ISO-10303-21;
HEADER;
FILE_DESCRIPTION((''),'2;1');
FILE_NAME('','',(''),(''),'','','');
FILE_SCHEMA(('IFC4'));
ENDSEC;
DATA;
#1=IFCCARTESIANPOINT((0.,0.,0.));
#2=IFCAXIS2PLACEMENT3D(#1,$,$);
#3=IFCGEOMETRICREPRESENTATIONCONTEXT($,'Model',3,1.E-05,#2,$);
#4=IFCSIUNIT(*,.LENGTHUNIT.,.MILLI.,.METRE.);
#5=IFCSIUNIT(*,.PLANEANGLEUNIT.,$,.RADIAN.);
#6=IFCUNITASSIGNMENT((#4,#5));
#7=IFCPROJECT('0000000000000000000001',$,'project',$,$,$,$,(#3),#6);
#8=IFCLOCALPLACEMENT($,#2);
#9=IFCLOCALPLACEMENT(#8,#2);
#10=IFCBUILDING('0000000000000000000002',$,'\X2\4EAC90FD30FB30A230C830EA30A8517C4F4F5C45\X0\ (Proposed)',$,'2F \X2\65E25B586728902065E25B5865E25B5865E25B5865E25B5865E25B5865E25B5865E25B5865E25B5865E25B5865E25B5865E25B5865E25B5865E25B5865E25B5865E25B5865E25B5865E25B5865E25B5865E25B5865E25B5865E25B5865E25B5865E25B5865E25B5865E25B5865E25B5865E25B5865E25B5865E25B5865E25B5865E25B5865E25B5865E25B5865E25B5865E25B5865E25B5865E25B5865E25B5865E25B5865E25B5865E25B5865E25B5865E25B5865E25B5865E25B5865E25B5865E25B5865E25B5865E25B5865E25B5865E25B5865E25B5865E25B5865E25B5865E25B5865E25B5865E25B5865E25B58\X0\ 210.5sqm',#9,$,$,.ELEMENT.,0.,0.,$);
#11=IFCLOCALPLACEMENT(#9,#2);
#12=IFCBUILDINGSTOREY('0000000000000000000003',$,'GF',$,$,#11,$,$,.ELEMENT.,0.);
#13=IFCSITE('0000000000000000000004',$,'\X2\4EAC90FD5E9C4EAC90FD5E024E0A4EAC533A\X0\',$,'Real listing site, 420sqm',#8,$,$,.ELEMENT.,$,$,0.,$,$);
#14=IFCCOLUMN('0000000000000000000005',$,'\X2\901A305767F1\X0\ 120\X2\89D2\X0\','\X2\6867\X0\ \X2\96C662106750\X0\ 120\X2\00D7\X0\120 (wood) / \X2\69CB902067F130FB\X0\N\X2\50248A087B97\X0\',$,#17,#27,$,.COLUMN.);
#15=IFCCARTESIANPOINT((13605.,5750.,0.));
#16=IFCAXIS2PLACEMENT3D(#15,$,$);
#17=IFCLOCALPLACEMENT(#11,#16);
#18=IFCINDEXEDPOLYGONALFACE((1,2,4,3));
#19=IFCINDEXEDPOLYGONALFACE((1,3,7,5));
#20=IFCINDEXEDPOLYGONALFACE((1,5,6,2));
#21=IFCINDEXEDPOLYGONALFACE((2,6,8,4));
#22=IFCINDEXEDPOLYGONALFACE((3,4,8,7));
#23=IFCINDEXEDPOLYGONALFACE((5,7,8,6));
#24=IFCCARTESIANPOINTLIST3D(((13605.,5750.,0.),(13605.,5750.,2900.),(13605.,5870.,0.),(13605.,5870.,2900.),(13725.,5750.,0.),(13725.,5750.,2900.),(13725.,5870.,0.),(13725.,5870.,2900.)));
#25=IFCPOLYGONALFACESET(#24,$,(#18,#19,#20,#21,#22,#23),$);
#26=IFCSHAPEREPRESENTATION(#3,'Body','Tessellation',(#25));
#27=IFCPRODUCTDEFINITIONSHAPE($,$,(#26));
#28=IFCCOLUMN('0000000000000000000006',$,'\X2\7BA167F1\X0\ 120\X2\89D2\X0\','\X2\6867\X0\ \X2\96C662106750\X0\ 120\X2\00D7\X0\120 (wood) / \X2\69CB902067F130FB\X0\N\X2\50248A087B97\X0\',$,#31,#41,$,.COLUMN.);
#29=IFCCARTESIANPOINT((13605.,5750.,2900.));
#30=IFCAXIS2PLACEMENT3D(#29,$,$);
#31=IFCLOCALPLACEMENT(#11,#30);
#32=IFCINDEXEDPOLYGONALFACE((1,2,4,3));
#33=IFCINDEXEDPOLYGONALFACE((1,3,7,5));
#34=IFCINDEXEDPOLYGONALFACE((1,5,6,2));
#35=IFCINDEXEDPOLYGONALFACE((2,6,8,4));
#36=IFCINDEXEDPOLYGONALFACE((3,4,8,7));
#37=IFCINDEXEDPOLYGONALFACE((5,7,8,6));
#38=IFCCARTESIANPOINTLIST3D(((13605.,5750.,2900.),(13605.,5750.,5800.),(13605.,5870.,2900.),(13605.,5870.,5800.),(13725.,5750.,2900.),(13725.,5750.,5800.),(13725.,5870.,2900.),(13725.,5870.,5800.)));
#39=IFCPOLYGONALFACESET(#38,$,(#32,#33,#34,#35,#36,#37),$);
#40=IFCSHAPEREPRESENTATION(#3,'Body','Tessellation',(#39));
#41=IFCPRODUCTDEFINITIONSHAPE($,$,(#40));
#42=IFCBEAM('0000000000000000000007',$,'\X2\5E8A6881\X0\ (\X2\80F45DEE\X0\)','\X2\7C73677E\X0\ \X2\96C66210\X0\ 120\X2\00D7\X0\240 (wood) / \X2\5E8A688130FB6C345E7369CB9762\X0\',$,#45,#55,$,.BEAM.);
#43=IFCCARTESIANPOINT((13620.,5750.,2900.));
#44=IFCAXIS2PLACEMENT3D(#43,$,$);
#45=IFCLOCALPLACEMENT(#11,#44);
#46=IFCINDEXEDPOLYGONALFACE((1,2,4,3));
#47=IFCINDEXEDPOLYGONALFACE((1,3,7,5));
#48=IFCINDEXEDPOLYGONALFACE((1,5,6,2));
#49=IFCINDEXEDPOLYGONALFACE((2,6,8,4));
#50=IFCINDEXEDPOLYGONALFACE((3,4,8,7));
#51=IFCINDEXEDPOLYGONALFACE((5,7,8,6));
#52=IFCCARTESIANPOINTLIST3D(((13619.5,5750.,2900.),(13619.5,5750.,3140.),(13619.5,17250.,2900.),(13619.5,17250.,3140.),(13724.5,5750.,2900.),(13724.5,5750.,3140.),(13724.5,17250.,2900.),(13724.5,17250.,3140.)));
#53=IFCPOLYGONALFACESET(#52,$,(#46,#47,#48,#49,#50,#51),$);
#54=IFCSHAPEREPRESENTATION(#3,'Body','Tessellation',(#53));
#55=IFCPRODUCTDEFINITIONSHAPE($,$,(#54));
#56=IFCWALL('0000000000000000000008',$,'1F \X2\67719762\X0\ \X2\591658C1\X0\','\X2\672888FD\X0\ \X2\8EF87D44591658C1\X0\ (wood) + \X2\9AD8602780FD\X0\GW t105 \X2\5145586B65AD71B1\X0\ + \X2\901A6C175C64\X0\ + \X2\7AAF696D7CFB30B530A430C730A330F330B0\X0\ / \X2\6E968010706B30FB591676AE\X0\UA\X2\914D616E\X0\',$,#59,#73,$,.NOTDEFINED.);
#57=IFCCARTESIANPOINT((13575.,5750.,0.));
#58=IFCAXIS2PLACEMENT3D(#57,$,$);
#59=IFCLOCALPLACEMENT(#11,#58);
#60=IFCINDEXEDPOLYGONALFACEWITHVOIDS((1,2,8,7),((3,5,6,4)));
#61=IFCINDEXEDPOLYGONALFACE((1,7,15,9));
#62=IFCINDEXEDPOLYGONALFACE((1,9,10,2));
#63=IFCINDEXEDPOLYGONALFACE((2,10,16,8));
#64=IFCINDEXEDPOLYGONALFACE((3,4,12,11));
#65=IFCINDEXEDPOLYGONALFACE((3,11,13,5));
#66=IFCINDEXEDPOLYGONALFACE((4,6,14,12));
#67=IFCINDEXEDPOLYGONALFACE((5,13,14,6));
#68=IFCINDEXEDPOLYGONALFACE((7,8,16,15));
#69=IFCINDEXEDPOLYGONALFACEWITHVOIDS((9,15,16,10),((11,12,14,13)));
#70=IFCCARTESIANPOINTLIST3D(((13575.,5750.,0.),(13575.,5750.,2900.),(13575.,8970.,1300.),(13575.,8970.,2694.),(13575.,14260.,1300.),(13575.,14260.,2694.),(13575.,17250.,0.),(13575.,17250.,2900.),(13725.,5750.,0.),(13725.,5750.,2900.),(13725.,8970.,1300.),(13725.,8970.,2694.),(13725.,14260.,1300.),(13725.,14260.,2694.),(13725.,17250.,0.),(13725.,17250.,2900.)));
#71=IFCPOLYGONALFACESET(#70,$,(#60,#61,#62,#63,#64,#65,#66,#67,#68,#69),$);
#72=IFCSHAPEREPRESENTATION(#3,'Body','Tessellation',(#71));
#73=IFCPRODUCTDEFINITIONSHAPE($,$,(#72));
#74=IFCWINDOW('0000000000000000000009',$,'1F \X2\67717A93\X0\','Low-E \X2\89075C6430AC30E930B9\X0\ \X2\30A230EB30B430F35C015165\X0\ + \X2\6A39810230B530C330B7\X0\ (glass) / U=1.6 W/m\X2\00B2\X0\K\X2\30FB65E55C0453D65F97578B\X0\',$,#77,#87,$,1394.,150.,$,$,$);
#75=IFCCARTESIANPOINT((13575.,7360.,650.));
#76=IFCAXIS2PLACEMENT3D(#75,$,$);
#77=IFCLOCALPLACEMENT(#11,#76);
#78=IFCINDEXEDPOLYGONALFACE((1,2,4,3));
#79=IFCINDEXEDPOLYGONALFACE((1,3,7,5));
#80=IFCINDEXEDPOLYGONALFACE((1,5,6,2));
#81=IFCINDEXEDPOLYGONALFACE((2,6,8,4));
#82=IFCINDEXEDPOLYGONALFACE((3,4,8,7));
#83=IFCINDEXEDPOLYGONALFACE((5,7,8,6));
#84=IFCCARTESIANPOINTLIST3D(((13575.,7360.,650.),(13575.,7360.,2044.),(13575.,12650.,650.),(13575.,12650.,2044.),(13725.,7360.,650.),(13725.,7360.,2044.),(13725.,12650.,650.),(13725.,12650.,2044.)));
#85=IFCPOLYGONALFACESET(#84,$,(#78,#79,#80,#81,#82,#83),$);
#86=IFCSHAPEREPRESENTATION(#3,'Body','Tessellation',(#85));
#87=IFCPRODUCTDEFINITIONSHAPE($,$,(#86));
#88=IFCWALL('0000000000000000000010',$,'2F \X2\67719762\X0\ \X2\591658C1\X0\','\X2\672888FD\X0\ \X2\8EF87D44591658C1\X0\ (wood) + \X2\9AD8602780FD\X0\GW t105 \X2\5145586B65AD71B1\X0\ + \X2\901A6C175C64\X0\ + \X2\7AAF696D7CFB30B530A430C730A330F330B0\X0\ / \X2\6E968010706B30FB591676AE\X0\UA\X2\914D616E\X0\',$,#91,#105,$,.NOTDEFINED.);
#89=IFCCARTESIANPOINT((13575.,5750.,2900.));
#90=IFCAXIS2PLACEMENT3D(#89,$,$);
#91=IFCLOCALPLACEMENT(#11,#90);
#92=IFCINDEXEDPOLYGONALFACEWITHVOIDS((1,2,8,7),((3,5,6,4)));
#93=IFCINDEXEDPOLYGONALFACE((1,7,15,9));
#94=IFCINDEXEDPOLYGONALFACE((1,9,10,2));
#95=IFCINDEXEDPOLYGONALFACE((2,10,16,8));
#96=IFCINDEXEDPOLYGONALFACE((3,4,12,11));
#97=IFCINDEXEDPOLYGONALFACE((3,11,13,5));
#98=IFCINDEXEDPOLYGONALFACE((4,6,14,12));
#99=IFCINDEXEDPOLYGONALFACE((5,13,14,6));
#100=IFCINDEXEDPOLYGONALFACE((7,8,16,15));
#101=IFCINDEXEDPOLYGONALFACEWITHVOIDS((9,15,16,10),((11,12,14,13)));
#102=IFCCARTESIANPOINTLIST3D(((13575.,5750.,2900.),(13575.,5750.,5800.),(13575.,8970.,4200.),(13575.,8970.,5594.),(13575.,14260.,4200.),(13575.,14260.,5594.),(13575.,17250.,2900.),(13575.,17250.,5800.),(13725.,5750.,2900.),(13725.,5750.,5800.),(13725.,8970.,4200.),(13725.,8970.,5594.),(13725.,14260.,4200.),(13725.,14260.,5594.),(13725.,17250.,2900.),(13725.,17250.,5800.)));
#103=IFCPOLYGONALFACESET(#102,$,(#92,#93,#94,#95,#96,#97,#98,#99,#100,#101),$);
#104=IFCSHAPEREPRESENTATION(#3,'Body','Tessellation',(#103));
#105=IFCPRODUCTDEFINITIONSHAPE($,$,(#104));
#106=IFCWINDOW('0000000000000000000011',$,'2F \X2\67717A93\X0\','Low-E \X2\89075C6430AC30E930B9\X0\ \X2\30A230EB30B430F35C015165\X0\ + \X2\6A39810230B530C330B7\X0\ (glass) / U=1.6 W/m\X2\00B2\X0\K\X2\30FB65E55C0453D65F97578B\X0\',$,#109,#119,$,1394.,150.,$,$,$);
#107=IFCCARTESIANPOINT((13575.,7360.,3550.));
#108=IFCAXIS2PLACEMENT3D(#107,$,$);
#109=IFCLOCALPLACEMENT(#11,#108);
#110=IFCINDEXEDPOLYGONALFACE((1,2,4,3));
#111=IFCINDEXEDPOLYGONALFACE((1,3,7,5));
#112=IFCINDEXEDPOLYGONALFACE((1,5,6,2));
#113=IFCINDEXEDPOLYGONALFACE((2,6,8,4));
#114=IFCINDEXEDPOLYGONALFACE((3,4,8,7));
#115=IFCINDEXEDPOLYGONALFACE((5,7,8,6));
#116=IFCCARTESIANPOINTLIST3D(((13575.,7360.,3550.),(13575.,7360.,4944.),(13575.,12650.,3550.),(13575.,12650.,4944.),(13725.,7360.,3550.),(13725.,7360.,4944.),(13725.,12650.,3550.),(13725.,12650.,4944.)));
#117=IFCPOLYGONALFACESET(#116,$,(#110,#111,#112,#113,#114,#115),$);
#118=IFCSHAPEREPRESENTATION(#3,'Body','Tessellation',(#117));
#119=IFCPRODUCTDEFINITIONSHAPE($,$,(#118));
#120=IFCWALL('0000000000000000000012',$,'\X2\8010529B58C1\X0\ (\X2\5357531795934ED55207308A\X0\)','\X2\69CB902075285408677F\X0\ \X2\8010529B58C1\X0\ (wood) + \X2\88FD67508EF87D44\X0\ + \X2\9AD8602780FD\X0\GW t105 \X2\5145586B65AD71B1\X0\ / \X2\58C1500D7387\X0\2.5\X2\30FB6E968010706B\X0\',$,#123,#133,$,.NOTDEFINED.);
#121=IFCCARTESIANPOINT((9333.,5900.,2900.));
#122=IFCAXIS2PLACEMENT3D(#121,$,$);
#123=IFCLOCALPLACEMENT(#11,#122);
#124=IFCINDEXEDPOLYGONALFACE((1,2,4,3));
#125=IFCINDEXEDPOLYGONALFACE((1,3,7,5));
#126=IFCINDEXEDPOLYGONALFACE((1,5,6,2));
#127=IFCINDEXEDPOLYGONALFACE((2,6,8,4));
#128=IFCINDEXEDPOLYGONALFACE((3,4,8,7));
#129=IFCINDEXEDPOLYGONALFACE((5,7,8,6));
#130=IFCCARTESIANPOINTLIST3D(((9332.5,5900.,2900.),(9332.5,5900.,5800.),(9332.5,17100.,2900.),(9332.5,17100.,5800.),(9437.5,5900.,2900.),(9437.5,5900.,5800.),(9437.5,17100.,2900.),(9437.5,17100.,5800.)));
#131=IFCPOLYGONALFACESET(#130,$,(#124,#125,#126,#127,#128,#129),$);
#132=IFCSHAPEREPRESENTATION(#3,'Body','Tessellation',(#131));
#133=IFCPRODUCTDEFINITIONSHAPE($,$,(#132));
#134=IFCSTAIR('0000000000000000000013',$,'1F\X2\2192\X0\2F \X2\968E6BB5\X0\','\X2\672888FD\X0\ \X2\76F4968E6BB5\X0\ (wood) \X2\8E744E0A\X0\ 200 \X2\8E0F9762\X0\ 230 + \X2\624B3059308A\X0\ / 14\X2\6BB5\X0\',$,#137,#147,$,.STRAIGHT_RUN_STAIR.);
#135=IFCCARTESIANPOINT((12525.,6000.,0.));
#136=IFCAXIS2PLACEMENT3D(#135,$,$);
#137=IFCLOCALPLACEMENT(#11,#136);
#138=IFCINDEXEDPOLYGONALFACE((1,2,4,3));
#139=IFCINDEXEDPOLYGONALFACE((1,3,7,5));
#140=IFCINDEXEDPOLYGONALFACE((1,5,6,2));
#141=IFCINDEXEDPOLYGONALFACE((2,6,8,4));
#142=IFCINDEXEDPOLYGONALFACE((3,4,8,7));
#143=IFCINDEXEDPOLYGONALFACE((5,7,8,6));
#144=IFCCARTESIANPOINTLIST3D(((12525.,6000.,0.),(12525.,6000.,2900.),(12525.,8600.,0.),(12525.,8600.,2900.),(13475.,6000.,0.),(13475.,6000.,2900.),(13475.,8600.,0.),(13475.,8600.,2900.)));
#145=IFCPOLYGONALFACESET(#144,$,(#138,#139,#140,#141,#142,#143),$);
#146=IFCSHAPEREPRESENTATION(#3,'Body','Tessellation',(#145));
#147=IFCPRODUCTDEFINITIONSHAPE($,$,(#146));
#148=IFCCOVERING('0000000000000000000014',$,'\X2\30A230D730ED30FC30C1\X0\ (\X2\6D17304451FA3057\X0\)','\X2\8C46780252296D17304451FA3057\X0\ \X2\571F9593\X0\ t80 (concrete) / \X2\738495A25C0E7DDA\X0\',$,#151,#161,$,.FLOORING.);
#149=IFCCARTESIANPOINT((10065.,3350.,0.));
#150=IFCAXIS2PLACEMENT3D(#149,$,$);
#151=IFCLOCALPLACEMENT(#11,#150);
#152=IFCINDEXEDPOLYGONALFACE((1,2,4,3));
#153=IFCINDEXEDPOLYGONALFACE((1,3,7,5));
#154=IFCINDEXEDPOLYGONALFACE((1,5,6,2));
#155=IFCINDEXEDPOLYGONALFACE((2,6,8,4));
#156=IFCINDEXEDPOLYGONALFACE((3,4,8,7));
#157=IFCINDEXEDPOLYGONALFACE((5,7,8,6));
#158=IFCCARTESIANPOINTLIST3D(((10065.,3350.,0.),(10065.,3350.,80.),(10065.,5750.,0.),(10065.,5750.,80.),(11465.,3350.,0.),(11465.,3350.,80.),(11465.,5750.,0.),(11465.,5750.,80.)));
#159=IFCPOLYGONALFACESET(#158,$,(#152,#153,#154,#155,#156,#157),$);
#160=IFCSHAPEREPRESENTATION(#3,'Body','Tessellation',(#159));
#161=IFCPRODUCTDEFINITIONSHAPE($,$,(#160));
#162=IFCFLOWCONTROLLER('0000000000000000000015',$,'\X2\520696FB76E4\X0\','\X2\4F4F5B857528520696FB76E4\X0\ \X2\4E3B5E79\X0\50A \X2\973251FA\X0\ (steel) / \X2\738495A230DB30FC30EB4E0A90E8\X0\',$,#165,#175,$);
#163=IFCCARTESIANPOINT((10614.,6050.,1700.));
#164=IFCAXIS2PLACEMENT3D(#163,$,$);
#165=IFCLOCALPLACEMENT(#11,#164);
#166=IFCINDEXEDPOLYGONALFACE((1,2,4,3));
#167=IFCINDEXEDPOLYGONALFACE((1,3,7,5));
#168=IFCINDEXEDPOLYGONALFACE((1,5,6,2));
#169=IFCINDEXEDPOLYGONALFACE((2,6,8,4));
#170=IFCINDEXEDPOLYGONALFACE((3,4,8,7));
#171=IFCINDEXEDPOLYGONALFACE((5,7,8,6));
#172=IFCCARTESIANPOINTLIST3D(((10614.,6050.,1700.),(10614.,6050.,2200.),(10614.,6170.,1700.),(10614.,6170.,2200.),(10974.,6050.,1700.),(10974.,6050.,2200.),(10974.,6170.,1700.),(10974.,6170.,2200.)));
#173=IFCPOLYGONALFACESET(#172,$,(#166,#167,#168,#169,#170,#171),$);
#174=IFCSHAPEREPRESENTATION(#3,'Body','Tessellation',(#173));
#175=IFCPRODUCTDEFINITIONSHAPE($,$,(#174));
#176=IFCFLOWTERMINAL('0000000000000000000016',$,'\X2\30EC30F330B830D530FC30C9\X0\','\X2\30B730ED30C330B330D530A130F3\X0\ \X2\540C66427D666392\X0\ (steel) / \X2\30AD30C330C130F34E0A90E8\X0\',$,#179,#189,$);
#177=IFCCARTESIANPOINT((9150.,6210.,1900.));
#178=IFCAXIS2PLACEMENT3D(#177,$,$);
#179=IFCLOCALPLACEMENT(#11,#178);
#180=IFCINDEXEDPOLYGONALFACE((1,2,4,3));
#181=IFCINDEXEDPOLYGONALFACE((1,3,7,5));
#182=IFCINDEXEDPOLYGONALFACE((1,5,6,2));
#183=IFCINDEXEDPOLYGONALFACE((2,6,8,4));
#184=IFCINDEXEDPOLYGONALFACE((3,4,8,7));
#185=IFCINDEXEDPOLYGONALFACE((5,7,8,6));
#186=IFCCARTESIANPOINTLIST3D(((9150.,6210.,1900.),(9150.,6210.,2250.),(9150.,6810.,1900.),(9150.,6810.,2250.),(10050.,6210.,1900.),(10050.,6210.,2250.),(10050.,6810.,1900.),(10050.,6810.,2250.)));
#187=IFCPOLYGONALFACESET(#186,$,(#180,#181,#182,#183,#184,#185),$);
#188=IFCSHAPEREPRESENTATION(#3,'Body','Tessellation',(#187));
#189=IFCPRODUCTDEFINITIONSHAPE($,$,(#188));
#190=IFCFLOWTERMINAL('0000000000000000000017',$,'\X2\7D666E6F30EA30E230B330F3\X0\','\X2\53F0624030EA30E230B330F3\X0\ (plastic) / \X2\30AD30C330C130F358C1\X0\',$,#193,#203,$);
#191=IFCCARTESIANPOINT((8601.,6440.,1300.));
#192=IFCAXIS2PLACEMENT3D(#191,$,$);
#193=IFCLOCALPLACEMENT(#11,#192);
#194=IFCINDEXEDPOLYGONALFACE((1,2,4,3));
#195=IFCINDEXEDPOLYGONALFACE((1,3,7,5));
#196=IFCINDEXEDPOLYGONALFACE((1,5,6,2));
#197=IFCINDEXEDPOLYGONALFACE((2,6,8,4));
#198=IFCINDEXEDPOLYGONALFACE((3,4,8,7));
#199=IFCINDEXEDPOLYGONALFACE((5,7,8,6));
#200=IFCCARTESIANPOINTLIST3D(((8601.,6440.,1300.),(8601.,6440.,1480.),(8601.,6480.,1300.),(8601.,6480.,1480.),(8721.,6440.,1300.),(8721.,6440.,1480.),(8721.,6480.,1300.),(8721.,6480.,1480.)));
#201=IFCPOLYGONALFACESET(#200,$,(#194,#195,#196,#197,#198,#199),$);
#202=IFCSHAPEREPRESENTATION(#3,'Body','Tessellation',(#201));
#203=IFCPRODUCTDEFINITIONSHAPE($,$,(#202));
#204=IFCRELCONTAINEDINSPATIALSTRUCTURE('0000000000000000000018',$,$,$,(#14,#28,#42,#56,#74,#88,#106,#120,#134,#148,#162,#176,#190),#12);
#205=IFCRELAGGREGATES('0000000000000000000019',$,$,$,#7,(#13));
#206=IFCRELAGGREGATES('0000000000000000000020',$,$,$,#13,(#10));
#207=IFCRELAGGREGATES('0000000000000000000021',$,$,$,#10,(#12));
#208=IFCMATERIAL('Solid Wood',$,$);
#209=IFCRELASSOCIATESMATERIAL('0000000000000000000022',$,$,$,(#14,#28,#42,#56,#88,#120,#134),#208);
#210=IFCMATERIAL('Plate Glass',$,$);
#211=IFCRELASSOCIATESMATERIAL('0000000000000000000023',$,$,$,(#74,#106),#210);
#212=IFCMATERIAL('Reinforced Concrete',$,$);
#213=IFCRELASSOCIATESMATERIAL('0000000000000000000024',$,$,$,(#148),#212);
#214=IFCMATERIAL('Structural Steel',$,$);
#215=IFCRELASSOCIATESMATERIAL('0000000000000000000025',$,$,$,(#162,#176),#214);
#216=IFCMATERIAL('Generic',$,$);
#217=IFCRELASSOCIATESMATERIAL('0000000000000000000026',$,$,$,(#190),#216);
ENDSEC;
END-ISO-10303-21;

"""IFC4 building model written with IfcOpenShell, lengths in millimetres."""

from ifc_helpers import new_model, si_unit, frame, frame_2d, origin, place, context, project, spatial, rectangle, extrude, material, element, fill, save


model = new_model("IFC4")

# Units and contexts
model_context = context("Model", 3, precision=1e-05, world=origin())
ifc_project = project(units=[si_unit("LENGTHUNIT", "METRE", prefix="MILLI"), si_unit("PLANEANGLEUNIT", "RADIAN")], contexts=[model_context])

# Site, building, storey
site_placement = place(None, origin())
site = spatial("IfcSite", under=ifc_project, at=site_placement, Name="京都府京都市上京区", ObjectType="Real listing site, 420sqm", CompositionType="ELEMENT", RefElevation=0.0)
building_placement = place(site_placement, origin())
building = spatial("IfcBuilding", under=site, at=building_placement, Name="京都・アトリエ兼住居 (Proposed)", ObjectType="2F 既存木造既存既存既存既存既存既存既存既存既存既存既存既存既存既存既存既存既存既存既存既存既存既存既存既存既存既存既存既存既存既存既存既存既存既存既存既存既存既存既存既存既存既存既存既存既存既存既存既存既存既存既存既存既存既存既存既存既存既存 210.5sqm", CompositionType="ELEMENT", ElevationOfRefHeight=0.0, ElevationOfTerrain=0.0)
storey_placement = place(building_placement, origin())
storey = spatial("IfcBuildingStorey", under=building, at=storey_placement, Name="GF", CompositionType="ELEMENT", Elevation=0.0)

# Columns
ifc_material_1 = material(Name="Solid Wood")
column_1_placement = place(storey_placement, frame((13605.0, 5750.0, 0.0)))
element("IfcColumn", 1, at=column_1_placement, inside=storey, material=ifc_material_1, Name="通し柱 120角", Description="桧 集成材 120×120 (wood) / 構造柱・N値計算", PredefinedType="COLUMN", context=model_context, shape_type="SweptSolid", body=[
    extrude(rectangle(XDim=120.0, YDim=120.0, at=frame_2d((60.0, 60.0))), frame((13605.0, 5750.0, 0.0)), (0.0, 0.0, 1.0), 2900.0),
])
column_2_placement = place(storey_placement, frame((13605.0, 5750.0, 2900.0)))
element("IfcColumn", 2, at=column_2_placement, inside=storey, material=ifc_material_1, Name="管柱 120角", Description="桧 集成材 120×120 (wood) / 構造柱・N値計算", PredefinedType="COLUMN", context=model_context, shape_type="SweptSolid", body=[
    extrude(rectangle(XDim=120.0, YDim=120.0, at=frame_2d((60.0, 60.0))), frame((13605.0, 5750.0, 2900.0)), (0.0, 0.0, 1.0), 2900.0),
])

# Beam
beam_1_placement = place(storey_placement, frame((13620.0, 5750.0, 2900.0)))
element("IfcBeam", 3, at=beam_1_placement, inside=storey, material=ifc_material_1, Name="床梁 (胴差)", Description="米松 集成 120×240 (wood) / 床梁・水平構面", PredefinedType="BEAM", context=model_context, shape_type="SweptSolid", body=[
    extrude(rectangle(XDim=105.0, YDim=11500.0, at=frame_2d((52.0, 5750.0))), frame((13620.0, 5750.0, 2900.0)), (0.0, 0.0, 1.0), 240.0),
])

# Wall, opening, window
wall_1_placement = place(storey_placement, frame((13575.0, 5750.0, 0.0)))
wall_1 = element("IfcWall", 4, at=wall_1_placement, inside=storey, material=ifc_material_1, Name="1F 東面 外壁", Description="木製 軸組外壁 (wood) + 高性能GW t105 充填断熱 + 通気層 + 窯業系サイディング / 準耐火・外皮UA配慮", PredefinedType="NOTDEFINED", context=model_context, shape_type="SweptSolid", body=[
    extrude(rectangle(XDim=150.0, YDim=11500.0, at=frame_2d((75.0, 5750.0))), frame((13575.0, 5750.0, 0.0)), (0.0, 0.0, 1.0), 2900.0),
])
opening_1_placement = place(storey_placement, frame((13575.0, 7360.0, 650.0)))
opening_1 = element("IfcOpeningElement", 5, at=opening_1_placement, cuts=wall_1, PredefinedType="NOTDEFINED", context=model_context, shape_type="SweptSolid", body=[
    extrude(rectangle(XDim=150.0, YDim=5290.0, at=frame_2d((75.0, 2645.0))), frame((13575.0, 7360.0, 650.0)), (0.0, 0.0, 1.0), 1394.0),
])
ifc_material_2 = material(Name="Plate Glass")
window_1_placement = place(storey_placement, frame((13575.0, 7360.0, 650.0)))
window_1 = element("IfcWindow", 6, at=window_1_placement, inside=storey, material=ifc_material_2, Name="1F 東窓", Description="Low-E 複層ガラス アルゴン封入 + 樹脂サッシ (glass) / U=1.6 W/m²K・日射取得型", OverallHeight=1394.0, OverallWidth=150.0, context=model_context, shape_type="SweptSolid", body=[
    extrude(rectangle(XDim=150.0, YDim=5290.0, at=frame_2d((75.0, 2645.0))), frame((13575.0, 7360.0, 650.0)), (0.0, 0.0, 1.0), 1394.0),
])
fill(opening_1, window_1)

# Wall, opening, window
wall_2_placement = place(storey_placement, frame((13575.0, 5750.0, 2900.0)))
wall_2 = element("IfcWall", 7, at=wall_2_placement, inside=storey, material=ifc_material_1, Name="2F 東面 外壁", Description="木製 軸組外壁 (wood) + 高性能GW t105 充填断熱 + 通気層 + 窯業系サイディング / 準耐火・外皮UA配慮", PredefinedType="NOTDEFINED", context=model_context, shape_type="SweptSolid", body=[
    extrude(rectangle(XDim=150.0, YDim=11500.0, at=frame_2d((75.0, 5750.0))), frame((13575.0, 5750.0, 2900.0)), (0.0, 0.0, 1.0), 2900.0),
])
opening_2_placement = place(storey_placement, frame((13575.0, 7360.0, 3550.0)))
opening_2 = element("IfcOpeningElement", 8, at=opening_2_placement, cuts=wall_2, PredefinedType="NOTDEFINED", context=model_context, shape_type="SweptSolid", body=[
    extrude(rectangle(XDim=150.0, YDim=5290.0, at=frame_2d((75.0, 2645.0))), frame((13575.0, 7360.0, 3550.0)), (0.0, 0.0, 1.0), 1394.0),
])
window_2_placement = place(storey_placement, frame((13575.0, 7360.0, 3550.0)))
window_2 = element("IfcWindow", 9, at=window_2_placement, inside=storey, material=ifc_material_2, Name="2F 東窓", Description="Low-E 複層ガラス アルゴン封入 + 樹脂サッシ (glass) / U=1.6 W/m²K・日射取得型", OverallHeight=1394.0, OverallWidth=150.0, context=model_context, shape_type="SweptSolid", body=[
    extrude(rectangle(XDim=150.0, YDim=5290.0, at=frame_2d((75.0, 2645.0))), frame((13575.0, 7360.0, 3550.0)), (0.0, 0.0, 1.0), 1394.0),
])
fill(opening_2, window_2)

# Wall
wall_3_placement = place(storey_placement, frame((9333.0, 5900.0, 2900.0)))
element("IfcWall", 10, at=wall_3_placement, inside=storey, material=ifc_material_1, Name="耐力壁 (南北間仕切り)", Description="構造用合板 耐力壁 (wood) + 製材軸組 + 高性能GW t105 充填断熱 / 壁倍率2.5・準耐火", PredefinedType="NOTDEFINED", context=model_context, shape_type="SweptSolid", body=[
    extrude(rectangle(XDim=105.0, YDim=11200.0, at=frame_2d((52.0, 5600.0))), frame((9333.0, 5900.0, 2900.0)), (0.0, 0.0, 1.0), 2900.0),
])

# Stair
stair_placement = place(storey_placement, frame((12525.0, 6000.0, 0.0)))
element("IfcStair", 11, at=stair_placement, inside=storey, material=ifc_material_1, Name="1F→2F 階段", Description="木製 直階段 (wood) 蹴上 200 踏面 230 + 手すり / 14段", PredefinedType="STRAIGHT_RUN_STAIR", context=model_context, shape_type="SweptSolid", body=[
    extrude(rectangle(XDim=950.0, YDim=2600.0, at=frame_2d((475.0, 1300.0))), frame((12525.0, 6000.0, 0.0)), (0.0, 0.0, 1.0), 2900.0),
])

# Covering
ifc_material_3 = material(Name="Reinforced Concrete")
covering_placement = place(storey_placement, frame((10065.0, 3350.0, 0.0)))
element("IfcCovering", 12, at=covering_placement, inside=storey, material=ifc_material_3, Name="アプローチ (洗い出し)", Description="豆砂利洗い出し 土間 t80 (concrete) / 玄関導線", PredefinedType="FLOORING", context=model_context, shape_type="SweptSolid", body=[
    extrude(rectangle(XDim=1400.0, YDim=2400.0, at=frame_2d((700.0, 1200.0))), frame((10065.0, 3350.0, 0.0)), (0.0, 0.0, 1.0), 80.0),
])

# Flow controller
ifc_material_4 = material(Name="Structural Steel")
flow_controller_placement = place(storey_placement, frame((10614.0, 6050.0, 1700.0)))
element("IfcFlowController", 13, at=flow_controller_placement, inside=storey, material=ifc_material_4, Name="分電盤", Description="住宅用分電盤 主幹50A 露出 (steel) / 玄関ホール上部", context=model_context, shape_type="SweptSolid", body=[
    extrude(rectangle(XDim=360.0, YDim=120.0, at=frame_2d((180.0, 60.0))), frame((10614.0, 6050.0, 1700.0)), (0.0, 0.0, 1.0), 500.0),
])

# Flow terminals
flow_terminal_1_placement = place(storey_placement, frame((9150.0, 6210.0, 1900.0)))
element("IfcFlowTerminal", 14, at=flow_terminal_1_placement, inside=storey, material=ifc_material_4, Name="レンジフード", Description="シロッコファン 同時給排 (steel) / キッチン上部", context=model_context, shape_type="SweptSolid", body=[
    extrude(rectangle(XDim=900.0, YDim=600.0, at=frame_2d((450.0, 300.0))), frame((9150.0, 6210.0, 1900.0)), (0.0, 0.0, 1.0), 350.0),
])
ifc_material_5 = material(Name="Generic")
flow_terminal_2_placement = place(storey_placement, frame((8601.0, 6440.0, 1300.0)))
element("IfcFlowTerminal", 15, at=flow_terminal_2_placement, inside=storey, material=ifc_material_5, Name="給湯リモコン", Description="台所リモコン (plastic) / キッチン壁", context=model_context, shape_type="SweptSolid", body=[
    extrude(rectangle(XDim=120.0, YDim=40.0, at=frame_2d((60.0, 20.0))), frame((8601.0, 6440.0, 1300.0)), (0.0, 0.0, 1.0), 180.0),
])

save(model, "model.ifc")
